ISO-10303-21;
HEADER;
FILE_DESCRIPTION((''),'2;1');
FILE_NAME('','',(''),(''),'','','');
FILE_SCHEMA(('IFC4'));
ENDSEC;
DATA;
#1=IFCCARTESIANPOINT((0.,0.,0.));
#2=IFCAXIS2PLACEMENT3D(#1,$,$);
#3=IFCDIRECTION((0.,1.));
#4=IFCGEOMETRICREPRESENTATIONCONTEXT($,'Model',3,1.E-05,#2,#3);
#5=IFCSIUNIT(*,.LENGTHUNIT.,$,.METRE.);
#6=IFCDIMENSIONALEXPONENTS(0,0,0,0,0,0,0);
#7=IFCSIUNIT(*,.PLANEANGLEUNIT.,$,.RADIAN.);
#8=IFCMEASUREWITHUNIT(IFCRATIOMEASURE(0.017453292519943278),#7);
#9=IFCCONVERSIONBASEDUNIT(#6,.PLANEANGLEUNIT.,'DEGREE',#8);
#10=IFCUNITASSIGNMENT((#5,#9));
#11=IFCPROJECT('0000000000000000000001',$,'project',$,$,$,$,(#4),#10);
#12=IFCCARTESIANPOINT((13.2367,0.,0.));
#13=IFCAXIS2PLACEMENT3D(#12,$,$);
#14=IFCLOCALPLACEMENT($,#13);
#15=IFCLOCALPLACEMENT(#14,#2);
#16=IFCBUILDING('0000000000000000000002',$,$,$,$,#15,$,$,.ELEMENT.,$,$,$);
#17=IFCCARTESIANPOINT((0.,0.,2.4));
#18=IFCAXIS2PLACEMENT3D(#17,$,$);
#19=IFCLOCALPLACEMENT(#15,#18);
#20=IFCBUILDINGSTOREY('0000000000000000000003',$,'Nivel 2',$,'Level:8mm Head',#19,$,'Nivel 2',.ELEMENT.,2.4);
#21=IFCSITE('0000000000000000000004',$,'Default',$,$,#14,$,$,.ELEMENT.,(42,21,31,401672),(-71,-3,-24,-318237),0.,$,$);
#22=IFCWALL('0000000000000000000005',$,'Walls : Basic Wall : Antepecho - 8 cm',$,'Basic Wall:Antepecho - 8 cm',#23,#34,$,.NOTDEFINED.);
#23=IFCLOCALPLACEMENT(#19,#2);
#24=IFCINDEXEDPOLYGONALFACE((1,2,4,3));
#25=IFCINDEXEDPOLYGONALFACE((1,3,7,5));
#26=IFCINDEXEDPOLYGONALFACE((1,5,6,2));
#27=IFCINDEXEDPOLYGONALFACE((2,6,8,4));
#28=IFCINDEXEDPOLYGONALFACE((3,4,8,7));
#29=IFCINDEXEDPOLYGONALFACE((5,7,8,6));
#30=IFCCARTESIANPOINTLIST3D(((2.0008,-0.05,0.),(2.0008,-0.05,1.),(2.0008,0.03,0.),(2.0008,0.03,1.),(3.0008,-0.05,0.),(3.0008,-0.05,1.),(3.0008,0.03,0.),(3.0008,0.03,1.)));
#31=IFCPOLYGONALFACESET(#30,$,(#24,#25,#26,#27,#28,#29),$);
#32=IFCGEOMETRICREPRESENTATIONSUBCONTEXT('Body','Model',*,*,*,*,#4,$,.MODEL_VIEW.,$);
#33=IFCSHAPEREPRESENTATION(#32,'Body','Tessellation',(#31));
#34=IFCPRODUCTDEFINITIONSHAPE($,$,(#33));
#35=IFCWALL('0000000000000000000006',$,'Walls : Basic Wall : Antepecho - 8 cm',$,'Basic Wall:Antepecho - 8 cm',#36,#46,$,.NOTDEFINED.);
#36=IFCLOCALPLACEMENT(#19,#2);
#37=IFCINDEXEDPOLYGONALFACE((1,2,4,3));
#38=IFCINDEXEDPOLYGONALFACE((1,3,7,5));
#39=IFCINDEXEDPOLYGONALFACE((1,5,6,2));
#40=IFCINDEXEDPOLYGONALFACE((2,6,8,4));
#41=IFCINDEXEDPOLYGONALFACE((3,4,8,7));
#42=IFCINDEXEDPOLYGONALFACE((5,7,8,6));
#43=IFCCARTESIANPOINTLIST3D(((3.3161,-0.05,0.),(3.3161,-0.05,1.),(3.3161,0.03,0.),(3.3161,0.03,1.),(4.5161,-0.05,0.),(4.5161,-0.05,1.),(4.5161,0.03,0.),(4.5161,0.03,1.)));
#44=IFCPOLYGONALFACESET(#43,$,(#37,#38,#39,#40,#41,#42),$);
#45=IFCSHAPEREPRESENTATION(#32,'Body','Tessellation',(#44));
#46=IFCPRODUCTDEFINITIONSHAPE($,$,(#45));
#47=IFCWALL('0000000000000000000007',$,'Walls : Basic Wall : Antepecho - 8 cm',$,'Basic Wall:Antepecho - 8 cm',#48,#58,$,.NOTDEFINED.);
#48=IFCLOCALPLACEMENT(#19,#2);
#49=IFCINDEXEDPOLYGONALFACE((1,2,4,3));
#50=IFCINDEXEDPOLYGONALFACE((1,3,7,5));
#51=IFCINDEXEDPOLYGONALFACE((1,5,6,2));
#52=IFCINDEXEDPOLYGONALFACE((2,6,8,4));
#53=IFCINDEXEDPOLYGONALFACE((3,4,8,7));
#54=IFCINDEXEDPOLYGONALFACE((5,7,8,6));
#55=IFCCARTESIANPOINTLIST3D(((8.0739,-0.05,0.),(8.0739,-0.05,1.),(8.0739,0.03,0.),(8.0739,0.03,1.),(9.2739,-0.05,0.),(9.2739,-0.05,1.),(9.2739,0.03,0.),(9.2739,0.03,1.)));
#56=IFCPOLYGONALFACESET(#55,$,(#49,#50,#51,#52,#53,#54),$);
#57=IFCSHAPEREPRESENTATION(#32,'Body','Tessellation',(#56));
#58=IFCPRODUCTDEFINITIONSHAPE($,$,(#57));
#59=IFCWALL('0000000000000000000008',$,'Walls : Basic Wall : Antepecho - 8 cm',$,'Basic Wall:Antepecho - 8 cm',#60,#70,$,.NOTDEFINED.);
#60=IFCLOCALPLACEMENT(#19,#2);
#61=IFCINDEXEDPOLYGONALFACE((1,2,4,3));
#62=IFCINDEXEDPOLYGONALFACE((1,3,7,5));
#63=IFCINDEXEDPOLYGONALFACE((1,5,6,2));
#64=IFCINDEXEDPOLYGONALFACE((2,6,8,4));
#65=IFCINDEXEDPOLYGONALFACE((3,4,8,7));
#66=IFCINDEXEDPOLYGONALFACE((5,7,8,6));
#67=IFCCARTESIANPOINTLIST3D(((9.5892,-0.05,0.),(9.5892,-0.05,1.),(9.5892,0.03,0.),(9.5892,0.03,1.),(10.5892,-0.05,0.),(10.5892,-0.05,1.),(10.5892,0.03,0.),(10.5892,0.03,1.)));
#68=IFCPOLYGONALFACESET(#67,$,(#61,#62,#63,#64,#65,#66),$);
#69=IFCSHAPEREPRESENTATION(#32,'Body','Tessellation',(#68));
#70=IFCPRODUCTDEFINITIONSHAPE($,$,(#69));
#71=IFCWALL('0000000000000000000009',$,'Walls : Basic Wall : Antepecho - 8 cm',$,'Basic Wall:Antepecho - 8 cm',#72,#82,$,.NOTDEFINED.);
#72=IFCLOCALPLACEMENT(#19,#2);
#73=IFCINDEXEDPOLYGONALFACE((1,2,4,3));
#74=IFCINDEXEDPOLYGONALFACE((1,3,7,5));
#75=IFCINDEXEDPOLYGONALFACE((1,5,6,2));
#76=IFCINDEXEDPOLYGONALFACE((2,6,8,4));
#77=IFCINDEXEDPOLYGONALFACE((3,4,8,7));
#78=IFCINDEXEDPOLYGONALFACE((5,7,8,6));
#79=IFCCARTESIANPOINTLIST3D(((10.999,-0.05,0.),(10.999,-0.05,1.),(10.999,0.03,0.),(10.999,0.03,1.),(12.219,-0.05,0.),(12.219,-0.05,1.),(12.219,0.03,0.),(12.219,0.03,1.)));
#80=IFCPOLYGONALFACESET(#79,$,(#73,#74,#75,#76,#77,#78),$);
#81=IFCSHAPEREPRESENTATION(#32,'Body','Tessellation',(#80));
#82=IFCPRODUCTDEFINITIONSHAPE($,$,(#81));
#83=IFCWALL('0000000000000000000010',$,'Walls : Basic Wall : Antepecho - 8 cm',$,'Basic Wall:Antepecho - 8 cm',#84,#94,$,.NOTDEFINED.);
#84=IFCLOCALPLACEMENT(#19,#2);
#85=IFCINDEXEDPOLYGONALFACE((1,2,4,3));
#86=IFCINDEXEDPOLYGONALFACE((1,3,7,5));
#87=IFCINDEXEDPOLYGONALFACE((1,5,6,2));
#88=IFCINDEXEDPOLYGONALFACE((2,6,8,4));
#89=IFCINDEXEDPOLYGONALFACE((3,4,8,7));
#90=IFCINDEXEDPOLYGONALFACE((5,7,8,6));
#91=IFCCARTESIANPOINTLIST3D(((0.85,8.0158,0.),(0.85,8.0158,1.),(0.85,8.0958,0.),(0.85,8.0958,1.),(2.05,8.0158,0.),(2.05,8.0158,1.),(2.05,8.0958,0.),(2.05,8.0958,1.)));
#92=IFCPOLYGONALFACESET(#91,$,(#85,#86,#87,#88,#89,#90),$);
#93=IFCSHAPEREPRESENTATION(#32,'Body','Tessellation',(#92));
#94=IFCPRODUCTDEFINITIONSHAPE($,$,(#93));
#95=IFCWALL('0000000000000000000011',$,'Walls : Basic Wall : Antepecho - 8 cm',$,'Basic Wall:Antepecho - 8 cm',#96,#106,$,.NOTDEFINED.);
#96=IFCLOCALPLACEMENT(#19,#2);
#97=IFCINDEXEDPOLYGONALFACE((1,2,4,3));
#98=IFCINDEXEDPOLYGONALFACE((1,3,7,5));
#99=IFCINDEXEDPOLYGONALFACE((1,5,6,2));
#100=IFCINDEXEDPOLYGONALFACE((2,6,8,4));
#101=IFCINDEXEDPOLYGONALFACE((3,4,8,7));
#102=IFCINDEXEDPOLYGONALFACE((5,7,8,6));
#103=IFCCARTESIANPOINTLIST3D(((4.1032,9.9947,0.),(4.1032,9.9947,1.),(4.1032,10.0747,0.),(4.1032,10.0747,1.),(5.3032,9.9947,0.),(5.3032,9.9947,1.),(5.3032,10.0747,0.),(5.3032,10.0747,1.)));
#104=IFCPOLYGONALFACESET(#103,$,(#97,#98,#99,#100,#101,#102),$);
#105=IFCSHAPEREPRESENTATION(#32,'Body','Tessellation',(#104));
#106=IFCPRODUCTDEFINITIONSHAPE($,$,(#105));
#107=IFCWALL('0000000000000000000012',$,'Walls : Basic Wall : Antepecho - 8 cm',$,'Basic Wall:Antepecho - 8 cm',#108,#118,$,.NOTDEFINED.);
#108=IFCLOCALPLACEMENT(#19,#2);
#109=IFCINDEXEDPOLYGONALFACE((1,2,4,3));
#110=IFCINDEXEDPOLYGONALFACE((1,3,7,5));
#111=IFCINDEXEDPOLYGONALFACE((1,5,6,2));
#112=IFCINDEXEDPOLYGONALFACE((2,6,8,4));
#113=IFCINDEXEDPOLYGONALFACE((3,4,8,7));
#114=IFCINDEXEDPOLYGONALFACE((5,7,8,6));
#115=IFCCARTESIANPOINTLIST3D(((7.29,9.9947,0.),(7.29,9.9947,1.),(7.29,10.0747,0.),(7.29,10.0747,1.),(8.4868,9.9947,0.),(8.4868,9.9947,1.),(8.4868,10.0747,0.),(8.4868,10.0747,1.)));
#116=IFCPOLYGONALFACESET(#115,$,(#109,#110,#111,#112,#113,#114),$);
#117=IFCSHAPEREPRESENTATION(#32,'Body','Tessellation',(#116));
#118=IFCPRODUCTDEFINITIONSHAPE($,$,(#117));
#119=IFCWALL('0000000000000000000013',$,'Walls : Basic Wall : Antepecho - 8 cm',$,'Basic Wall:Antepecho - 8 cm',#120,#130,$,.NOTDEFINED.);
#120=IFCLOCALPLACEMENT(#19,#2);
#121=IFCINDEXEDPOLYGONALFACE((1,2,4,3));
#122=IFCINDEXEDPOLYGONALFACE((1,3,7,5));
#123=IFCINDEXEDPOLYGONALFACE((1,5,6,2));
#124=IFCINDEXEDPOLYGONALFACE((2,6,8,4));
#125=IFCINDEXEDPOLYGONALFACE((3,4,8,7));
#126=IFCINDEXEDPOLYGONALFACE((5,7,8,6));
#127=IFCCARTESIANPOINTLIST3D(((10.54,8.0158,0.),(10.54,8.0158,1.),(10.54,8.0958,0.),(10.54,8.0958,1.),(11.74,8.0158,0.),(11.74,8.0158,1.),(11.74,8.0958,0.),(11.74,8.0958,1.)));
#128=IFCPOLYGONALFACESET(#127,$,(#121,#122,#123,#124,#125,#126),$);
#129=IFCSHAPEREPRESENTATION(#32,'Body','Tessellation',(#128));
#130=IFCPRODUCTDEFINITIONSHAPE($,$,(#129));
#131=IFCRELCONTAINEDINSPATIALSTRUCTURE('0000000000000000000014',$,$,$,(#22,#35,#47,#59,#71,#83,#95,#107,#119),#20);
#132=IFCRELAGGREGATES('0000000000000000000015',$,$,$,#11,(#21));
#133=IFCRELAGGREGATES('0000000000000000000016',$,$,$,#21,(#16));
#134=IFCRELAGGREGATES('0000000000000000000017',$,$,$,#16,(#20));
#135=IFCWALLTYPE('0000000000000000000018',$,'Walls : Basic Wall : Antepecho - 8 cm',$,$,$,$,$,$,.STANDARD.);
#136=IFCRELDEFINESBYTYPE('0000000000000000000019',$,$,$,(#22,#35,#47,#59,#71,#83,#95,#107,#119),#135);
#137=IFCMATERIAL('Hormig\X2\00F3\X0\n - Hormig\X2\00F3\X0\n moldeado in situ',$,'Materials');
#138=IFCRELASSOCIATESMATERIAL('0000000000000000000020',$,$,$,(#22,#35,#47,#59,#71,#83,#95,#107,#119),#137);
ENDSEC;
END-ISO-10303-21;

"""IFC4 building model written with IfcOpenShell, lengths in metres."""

from ifc_helpers import new_model, entity, si_unit, converted_unit, direction, frame, origin, place, context, subcontext, project, spatial, indexed_curve, outline, extrude, material, type_object, element, save


model = new_model("IFC4")

# Units and contexts
model_context = context("Model", 3, precision=1e-05, world=origin(), true_north=direction((0.0, 1.0)))
body_context = subcontext(model_context, "Body", "Model", "MODEL_VIEW")
ifc_project = project(units=[si_unit("LENGTHUNIT", "METRE"), converted_unit("PLANEANGLEUNIT", "DEGREE", entity("IfcRatioMeasure", 0.017453292519943278), si_unit("PLANEANGLEUNIT", "RADIAN"), dimensions=[0, 0, 0, 0, 0, 0, 0])], contexts=[model_context])

# Site, building, storey
site_placement = place(None, frame((13.2367, 0.0, 0.0)))
site = spatial("IfcSite", under=ifc_project, at=site_placement, Name="Default", CompositionType="ELEMENT", RefLatitude=(42, 21, 31, 401672), RefLongitude=(-71, -3, -24, -318237), RefElevation=0.0)
building_placement = place(site_placement, origin())
building = spatial("IfcBuilding", under=site, at=building_placement, CompositionType="ELEMENT")
storey_placement = place(building_placement, frame((0.0, 0.0, 2.4)))
storey = spatial("IfcBuildingStorey", under=building, at=storey_placement, Name="Nivel 2", ObjectType="Level:8mm Head", LongName="Nivel 2", CompositionType="ELEMENT", Elevation=2.4)

# Shared definitions
ifc_material_1 = material(Name="Hormigón - Hormigón moldeado in situ", Category="Materials")

# Walls
wall_type = type_object("IfcWallType", Name="Walls : Basic Wall : Antepecho - 8 cm", PredefinedType="STANDARD")
wall_1_placement = place(storey_placement, frame((2.0008, -0.01, 0.0)))
element("IfcWall", 1, at=wall_1_placement, inside=storey, type_object=wall_type, material=ifc_material_1, Name="Walls : Basic Wall : Antepecho - 8 cm", ObjectType="Basic Wall:Antepecho - 8 cm", PredefinedType="NOTDEFINED", context=body_context, shape_type="SweptSolid", body=[
    extrude(outline(indexed_curve([(1.0, 0.04), (0.0, 0.04), (0.0, -0.04), (1.0, -0.04), (1.0, 0.04)], self_intersect=False)), origin(), (0.0, 0.0, 1.0), 1.0),
])
wall_2_placement = place(storey_placement, frame((3.3161, -0.01, 0.0)))
element("IfcWall", 2, at=wall_2_placement, inside=storey, type_object=wall_type, material=ifc_material_1, Name="Walls : Basic Wall : Antepecho - 8 cm", ObjectType="Basic Wall:Antepecho - 8 cm", PredefinedType="NOTDEFINED", context=body_context, shape_type="SweptSolid", body=[
    extrude(outline(indexed_curve([(1.2, 0.04), (0.0, 0.04), (0.0, -0.04), (1.2, -0.04), (1.2, 0.04)], self_intersect=False)), origin(), (0.0, 0.0, 1.0), 1.0),
])
wall_3_placement = place(storey_placement, frame((8.0739, -0.01, 0.0)))
element("IfcWall", 3, at=wall_3_placement, inside=storey, type_object=wall_type, material=ifc_material_1, Name="Walls : Basic Wall : Antepecho - 8 cm", ObjectType="Basic Wall:Antepecho - 8 cm", PredefinedType="NOTDEFINED", context=body_context, shape_type="SweptSolid", body=[
    extrude(outline(indexed_curve([(1.2, 0.04), (0.0, 0.04), (0.0, -0.04), (1.2, -0.04), (1.2, 0.04)], self_intersect=False)), origin(), (0.0, 0.0, 1.0), 1.0),
])
wall_4_placement = place(storey_placement, frame((9.5892, -0.01, 0.0)))
element("IfcWall", 4, at=wall_4_placement, inside=storey, type_object=wall_type, material=ifc_material_1, Name="Walls : Basic Wall : Antepecho - 8 cm", ObjectType="Basic Wall:Antepecho - 8 cm", PredefinedType="NOTDEFINED", context=body_context, shape_type="SweptSolid", body=[
    extrude(outline(indexed_curve([(1.0, 0.04), (0.0, 0.04), (0.0, -0.04), (1.0, -0.04), (1.0, 0.04)], self_intersect=False)), origin(), (0.0, 0.0, 1.0), 1.0),
])
wall_5_placement = place(storey_placement, frame((10.999, -0.01, 0.0)))
element("IfcWall", 5, at=wall_5_placement, inside=storey, type_object=wall_type, material=ifc_material_1, Name="Walls : Basic Wall : Antepecho - 8 cm", ObjectType="Basic Wall:Antepecho - 8 cm", PredefinedType="NOTDEFINED", context=body_context, shape_type="SweptSolid", body=[
    extrude(outline(indexed_curve([(1.22, 0.04), (0.0, 0.04), (0.0, -0.04), (1.22, -0.04), (1.22, 0.04)], self_intersect=False)), origin(), (0.0, 0.0, 1.0), 1.0),
])
wall_6_placement = place(storey_placement, frame((2.05, 8.0558, 0.0), z_axis=(0.0, 0.0, 1.0), x_axis=(-1.0, 0.0, 0.0)))
element("IfcWall", 6, at=wall_6_placement, inside=storey, type_object=wall_type, material=ifc_material_1, Name="Walls : Basic Wall : Antepecho - 8 cm", ObjectType="Basic Wall:Antepecho - 8 cm", PredefinedType="NOTDEFINED", context=body_context, shape_type="SweptSolid", body=[
    extrude(outline(indexed_curve([(1.2, 0.04), (0.0, 0.04), (0.0, -0.04), (1.2, -0.04), (1.2, 0.04)], self_intersect=False)), origin(), (0.0, 0.0, 1.0), 1.0),
])
wall_7_placement = place(storey_placement, frame((5.3032, 10.0347, 0.0), z_axis=(0.0, 0.0, 1.0), x_axis=(-1.0, 0.0, 0.0)))
element("IfcWall", 7, at=wall_7_placement, inside=storey, type_object=wall_type, material=ifc_material_1, Name="Walls : Basic Wall : Antepecho - 8 cm", ObjectType="Basic Wall:Antepecho - 8 cm", PredefinedType="NOTDEFINED", context=body_context, shape_type="SweptSolid", body=[
    extrude(outline(indexed_curve([(1.2, 0.04), (0.0, 0.04), (0.0, -0.04), (1.2, -0.04), (1.2, 0.04)], self_intersect=False)), origin(), (0.0, 0.0, 1.0), 1.0),
])
wall_8_placement = place(storey_placement, frame((8.4868, 10.0347, 0.0), z_axis=(0.0, 0.0, 1.0), x_axis=(-1.0, 0.0, 0.0)))
element("IfcWall", 8, at=wall_8_placement, inside=storey, type_object=wall_type, material=ifc_material_1, Name="Walls : Basic Wall : Antepecho - 8 cm", ObjectType="Basic Wall:Antepecho - 8 cm", PredefinedType="NOTDEFINED", context=body_context, shape_type="SweptSolid", body=[
    extrude(outline(indexed_curve([(1.1968, 0.04), (0.0, 0.04), (0.0, -0.04), (1.1968, -0.04), (1.1968, 0.04)], self_intersect=False)), origin(), (0.0, 0.0, 1.0), 1.0),
])
wall_9_placement = place(storey_placement, frame((11.74, 8.0558, 0.0), z_axis=(0.0, 0.0, 1.0), x_axis=(-1.0, 0.0, 0.0)))
element("IfcWall", 9, at=wall_9_placement, inside=storey, type_object=wall_type, material=ifc_material_1, Name="Walls : Basic Wall : Antepecho - 8 cm", ObjectType="Basic Wall:Antepecho - 8 cm", PredefinedType="NOTDEFINED", context=body_context, shape_type="SweptSolid", body=[
    extrude(outline(indexed_curve([(1.2, 0.04), (0.0, 0.04), (0.0, -0.04), (1.2, -0.04), (1.2, 0.04)], self_intersect=False)), origin(), (0.0, 0.0, 1.0), 1.0),
])

save(model, "model.ifc")
